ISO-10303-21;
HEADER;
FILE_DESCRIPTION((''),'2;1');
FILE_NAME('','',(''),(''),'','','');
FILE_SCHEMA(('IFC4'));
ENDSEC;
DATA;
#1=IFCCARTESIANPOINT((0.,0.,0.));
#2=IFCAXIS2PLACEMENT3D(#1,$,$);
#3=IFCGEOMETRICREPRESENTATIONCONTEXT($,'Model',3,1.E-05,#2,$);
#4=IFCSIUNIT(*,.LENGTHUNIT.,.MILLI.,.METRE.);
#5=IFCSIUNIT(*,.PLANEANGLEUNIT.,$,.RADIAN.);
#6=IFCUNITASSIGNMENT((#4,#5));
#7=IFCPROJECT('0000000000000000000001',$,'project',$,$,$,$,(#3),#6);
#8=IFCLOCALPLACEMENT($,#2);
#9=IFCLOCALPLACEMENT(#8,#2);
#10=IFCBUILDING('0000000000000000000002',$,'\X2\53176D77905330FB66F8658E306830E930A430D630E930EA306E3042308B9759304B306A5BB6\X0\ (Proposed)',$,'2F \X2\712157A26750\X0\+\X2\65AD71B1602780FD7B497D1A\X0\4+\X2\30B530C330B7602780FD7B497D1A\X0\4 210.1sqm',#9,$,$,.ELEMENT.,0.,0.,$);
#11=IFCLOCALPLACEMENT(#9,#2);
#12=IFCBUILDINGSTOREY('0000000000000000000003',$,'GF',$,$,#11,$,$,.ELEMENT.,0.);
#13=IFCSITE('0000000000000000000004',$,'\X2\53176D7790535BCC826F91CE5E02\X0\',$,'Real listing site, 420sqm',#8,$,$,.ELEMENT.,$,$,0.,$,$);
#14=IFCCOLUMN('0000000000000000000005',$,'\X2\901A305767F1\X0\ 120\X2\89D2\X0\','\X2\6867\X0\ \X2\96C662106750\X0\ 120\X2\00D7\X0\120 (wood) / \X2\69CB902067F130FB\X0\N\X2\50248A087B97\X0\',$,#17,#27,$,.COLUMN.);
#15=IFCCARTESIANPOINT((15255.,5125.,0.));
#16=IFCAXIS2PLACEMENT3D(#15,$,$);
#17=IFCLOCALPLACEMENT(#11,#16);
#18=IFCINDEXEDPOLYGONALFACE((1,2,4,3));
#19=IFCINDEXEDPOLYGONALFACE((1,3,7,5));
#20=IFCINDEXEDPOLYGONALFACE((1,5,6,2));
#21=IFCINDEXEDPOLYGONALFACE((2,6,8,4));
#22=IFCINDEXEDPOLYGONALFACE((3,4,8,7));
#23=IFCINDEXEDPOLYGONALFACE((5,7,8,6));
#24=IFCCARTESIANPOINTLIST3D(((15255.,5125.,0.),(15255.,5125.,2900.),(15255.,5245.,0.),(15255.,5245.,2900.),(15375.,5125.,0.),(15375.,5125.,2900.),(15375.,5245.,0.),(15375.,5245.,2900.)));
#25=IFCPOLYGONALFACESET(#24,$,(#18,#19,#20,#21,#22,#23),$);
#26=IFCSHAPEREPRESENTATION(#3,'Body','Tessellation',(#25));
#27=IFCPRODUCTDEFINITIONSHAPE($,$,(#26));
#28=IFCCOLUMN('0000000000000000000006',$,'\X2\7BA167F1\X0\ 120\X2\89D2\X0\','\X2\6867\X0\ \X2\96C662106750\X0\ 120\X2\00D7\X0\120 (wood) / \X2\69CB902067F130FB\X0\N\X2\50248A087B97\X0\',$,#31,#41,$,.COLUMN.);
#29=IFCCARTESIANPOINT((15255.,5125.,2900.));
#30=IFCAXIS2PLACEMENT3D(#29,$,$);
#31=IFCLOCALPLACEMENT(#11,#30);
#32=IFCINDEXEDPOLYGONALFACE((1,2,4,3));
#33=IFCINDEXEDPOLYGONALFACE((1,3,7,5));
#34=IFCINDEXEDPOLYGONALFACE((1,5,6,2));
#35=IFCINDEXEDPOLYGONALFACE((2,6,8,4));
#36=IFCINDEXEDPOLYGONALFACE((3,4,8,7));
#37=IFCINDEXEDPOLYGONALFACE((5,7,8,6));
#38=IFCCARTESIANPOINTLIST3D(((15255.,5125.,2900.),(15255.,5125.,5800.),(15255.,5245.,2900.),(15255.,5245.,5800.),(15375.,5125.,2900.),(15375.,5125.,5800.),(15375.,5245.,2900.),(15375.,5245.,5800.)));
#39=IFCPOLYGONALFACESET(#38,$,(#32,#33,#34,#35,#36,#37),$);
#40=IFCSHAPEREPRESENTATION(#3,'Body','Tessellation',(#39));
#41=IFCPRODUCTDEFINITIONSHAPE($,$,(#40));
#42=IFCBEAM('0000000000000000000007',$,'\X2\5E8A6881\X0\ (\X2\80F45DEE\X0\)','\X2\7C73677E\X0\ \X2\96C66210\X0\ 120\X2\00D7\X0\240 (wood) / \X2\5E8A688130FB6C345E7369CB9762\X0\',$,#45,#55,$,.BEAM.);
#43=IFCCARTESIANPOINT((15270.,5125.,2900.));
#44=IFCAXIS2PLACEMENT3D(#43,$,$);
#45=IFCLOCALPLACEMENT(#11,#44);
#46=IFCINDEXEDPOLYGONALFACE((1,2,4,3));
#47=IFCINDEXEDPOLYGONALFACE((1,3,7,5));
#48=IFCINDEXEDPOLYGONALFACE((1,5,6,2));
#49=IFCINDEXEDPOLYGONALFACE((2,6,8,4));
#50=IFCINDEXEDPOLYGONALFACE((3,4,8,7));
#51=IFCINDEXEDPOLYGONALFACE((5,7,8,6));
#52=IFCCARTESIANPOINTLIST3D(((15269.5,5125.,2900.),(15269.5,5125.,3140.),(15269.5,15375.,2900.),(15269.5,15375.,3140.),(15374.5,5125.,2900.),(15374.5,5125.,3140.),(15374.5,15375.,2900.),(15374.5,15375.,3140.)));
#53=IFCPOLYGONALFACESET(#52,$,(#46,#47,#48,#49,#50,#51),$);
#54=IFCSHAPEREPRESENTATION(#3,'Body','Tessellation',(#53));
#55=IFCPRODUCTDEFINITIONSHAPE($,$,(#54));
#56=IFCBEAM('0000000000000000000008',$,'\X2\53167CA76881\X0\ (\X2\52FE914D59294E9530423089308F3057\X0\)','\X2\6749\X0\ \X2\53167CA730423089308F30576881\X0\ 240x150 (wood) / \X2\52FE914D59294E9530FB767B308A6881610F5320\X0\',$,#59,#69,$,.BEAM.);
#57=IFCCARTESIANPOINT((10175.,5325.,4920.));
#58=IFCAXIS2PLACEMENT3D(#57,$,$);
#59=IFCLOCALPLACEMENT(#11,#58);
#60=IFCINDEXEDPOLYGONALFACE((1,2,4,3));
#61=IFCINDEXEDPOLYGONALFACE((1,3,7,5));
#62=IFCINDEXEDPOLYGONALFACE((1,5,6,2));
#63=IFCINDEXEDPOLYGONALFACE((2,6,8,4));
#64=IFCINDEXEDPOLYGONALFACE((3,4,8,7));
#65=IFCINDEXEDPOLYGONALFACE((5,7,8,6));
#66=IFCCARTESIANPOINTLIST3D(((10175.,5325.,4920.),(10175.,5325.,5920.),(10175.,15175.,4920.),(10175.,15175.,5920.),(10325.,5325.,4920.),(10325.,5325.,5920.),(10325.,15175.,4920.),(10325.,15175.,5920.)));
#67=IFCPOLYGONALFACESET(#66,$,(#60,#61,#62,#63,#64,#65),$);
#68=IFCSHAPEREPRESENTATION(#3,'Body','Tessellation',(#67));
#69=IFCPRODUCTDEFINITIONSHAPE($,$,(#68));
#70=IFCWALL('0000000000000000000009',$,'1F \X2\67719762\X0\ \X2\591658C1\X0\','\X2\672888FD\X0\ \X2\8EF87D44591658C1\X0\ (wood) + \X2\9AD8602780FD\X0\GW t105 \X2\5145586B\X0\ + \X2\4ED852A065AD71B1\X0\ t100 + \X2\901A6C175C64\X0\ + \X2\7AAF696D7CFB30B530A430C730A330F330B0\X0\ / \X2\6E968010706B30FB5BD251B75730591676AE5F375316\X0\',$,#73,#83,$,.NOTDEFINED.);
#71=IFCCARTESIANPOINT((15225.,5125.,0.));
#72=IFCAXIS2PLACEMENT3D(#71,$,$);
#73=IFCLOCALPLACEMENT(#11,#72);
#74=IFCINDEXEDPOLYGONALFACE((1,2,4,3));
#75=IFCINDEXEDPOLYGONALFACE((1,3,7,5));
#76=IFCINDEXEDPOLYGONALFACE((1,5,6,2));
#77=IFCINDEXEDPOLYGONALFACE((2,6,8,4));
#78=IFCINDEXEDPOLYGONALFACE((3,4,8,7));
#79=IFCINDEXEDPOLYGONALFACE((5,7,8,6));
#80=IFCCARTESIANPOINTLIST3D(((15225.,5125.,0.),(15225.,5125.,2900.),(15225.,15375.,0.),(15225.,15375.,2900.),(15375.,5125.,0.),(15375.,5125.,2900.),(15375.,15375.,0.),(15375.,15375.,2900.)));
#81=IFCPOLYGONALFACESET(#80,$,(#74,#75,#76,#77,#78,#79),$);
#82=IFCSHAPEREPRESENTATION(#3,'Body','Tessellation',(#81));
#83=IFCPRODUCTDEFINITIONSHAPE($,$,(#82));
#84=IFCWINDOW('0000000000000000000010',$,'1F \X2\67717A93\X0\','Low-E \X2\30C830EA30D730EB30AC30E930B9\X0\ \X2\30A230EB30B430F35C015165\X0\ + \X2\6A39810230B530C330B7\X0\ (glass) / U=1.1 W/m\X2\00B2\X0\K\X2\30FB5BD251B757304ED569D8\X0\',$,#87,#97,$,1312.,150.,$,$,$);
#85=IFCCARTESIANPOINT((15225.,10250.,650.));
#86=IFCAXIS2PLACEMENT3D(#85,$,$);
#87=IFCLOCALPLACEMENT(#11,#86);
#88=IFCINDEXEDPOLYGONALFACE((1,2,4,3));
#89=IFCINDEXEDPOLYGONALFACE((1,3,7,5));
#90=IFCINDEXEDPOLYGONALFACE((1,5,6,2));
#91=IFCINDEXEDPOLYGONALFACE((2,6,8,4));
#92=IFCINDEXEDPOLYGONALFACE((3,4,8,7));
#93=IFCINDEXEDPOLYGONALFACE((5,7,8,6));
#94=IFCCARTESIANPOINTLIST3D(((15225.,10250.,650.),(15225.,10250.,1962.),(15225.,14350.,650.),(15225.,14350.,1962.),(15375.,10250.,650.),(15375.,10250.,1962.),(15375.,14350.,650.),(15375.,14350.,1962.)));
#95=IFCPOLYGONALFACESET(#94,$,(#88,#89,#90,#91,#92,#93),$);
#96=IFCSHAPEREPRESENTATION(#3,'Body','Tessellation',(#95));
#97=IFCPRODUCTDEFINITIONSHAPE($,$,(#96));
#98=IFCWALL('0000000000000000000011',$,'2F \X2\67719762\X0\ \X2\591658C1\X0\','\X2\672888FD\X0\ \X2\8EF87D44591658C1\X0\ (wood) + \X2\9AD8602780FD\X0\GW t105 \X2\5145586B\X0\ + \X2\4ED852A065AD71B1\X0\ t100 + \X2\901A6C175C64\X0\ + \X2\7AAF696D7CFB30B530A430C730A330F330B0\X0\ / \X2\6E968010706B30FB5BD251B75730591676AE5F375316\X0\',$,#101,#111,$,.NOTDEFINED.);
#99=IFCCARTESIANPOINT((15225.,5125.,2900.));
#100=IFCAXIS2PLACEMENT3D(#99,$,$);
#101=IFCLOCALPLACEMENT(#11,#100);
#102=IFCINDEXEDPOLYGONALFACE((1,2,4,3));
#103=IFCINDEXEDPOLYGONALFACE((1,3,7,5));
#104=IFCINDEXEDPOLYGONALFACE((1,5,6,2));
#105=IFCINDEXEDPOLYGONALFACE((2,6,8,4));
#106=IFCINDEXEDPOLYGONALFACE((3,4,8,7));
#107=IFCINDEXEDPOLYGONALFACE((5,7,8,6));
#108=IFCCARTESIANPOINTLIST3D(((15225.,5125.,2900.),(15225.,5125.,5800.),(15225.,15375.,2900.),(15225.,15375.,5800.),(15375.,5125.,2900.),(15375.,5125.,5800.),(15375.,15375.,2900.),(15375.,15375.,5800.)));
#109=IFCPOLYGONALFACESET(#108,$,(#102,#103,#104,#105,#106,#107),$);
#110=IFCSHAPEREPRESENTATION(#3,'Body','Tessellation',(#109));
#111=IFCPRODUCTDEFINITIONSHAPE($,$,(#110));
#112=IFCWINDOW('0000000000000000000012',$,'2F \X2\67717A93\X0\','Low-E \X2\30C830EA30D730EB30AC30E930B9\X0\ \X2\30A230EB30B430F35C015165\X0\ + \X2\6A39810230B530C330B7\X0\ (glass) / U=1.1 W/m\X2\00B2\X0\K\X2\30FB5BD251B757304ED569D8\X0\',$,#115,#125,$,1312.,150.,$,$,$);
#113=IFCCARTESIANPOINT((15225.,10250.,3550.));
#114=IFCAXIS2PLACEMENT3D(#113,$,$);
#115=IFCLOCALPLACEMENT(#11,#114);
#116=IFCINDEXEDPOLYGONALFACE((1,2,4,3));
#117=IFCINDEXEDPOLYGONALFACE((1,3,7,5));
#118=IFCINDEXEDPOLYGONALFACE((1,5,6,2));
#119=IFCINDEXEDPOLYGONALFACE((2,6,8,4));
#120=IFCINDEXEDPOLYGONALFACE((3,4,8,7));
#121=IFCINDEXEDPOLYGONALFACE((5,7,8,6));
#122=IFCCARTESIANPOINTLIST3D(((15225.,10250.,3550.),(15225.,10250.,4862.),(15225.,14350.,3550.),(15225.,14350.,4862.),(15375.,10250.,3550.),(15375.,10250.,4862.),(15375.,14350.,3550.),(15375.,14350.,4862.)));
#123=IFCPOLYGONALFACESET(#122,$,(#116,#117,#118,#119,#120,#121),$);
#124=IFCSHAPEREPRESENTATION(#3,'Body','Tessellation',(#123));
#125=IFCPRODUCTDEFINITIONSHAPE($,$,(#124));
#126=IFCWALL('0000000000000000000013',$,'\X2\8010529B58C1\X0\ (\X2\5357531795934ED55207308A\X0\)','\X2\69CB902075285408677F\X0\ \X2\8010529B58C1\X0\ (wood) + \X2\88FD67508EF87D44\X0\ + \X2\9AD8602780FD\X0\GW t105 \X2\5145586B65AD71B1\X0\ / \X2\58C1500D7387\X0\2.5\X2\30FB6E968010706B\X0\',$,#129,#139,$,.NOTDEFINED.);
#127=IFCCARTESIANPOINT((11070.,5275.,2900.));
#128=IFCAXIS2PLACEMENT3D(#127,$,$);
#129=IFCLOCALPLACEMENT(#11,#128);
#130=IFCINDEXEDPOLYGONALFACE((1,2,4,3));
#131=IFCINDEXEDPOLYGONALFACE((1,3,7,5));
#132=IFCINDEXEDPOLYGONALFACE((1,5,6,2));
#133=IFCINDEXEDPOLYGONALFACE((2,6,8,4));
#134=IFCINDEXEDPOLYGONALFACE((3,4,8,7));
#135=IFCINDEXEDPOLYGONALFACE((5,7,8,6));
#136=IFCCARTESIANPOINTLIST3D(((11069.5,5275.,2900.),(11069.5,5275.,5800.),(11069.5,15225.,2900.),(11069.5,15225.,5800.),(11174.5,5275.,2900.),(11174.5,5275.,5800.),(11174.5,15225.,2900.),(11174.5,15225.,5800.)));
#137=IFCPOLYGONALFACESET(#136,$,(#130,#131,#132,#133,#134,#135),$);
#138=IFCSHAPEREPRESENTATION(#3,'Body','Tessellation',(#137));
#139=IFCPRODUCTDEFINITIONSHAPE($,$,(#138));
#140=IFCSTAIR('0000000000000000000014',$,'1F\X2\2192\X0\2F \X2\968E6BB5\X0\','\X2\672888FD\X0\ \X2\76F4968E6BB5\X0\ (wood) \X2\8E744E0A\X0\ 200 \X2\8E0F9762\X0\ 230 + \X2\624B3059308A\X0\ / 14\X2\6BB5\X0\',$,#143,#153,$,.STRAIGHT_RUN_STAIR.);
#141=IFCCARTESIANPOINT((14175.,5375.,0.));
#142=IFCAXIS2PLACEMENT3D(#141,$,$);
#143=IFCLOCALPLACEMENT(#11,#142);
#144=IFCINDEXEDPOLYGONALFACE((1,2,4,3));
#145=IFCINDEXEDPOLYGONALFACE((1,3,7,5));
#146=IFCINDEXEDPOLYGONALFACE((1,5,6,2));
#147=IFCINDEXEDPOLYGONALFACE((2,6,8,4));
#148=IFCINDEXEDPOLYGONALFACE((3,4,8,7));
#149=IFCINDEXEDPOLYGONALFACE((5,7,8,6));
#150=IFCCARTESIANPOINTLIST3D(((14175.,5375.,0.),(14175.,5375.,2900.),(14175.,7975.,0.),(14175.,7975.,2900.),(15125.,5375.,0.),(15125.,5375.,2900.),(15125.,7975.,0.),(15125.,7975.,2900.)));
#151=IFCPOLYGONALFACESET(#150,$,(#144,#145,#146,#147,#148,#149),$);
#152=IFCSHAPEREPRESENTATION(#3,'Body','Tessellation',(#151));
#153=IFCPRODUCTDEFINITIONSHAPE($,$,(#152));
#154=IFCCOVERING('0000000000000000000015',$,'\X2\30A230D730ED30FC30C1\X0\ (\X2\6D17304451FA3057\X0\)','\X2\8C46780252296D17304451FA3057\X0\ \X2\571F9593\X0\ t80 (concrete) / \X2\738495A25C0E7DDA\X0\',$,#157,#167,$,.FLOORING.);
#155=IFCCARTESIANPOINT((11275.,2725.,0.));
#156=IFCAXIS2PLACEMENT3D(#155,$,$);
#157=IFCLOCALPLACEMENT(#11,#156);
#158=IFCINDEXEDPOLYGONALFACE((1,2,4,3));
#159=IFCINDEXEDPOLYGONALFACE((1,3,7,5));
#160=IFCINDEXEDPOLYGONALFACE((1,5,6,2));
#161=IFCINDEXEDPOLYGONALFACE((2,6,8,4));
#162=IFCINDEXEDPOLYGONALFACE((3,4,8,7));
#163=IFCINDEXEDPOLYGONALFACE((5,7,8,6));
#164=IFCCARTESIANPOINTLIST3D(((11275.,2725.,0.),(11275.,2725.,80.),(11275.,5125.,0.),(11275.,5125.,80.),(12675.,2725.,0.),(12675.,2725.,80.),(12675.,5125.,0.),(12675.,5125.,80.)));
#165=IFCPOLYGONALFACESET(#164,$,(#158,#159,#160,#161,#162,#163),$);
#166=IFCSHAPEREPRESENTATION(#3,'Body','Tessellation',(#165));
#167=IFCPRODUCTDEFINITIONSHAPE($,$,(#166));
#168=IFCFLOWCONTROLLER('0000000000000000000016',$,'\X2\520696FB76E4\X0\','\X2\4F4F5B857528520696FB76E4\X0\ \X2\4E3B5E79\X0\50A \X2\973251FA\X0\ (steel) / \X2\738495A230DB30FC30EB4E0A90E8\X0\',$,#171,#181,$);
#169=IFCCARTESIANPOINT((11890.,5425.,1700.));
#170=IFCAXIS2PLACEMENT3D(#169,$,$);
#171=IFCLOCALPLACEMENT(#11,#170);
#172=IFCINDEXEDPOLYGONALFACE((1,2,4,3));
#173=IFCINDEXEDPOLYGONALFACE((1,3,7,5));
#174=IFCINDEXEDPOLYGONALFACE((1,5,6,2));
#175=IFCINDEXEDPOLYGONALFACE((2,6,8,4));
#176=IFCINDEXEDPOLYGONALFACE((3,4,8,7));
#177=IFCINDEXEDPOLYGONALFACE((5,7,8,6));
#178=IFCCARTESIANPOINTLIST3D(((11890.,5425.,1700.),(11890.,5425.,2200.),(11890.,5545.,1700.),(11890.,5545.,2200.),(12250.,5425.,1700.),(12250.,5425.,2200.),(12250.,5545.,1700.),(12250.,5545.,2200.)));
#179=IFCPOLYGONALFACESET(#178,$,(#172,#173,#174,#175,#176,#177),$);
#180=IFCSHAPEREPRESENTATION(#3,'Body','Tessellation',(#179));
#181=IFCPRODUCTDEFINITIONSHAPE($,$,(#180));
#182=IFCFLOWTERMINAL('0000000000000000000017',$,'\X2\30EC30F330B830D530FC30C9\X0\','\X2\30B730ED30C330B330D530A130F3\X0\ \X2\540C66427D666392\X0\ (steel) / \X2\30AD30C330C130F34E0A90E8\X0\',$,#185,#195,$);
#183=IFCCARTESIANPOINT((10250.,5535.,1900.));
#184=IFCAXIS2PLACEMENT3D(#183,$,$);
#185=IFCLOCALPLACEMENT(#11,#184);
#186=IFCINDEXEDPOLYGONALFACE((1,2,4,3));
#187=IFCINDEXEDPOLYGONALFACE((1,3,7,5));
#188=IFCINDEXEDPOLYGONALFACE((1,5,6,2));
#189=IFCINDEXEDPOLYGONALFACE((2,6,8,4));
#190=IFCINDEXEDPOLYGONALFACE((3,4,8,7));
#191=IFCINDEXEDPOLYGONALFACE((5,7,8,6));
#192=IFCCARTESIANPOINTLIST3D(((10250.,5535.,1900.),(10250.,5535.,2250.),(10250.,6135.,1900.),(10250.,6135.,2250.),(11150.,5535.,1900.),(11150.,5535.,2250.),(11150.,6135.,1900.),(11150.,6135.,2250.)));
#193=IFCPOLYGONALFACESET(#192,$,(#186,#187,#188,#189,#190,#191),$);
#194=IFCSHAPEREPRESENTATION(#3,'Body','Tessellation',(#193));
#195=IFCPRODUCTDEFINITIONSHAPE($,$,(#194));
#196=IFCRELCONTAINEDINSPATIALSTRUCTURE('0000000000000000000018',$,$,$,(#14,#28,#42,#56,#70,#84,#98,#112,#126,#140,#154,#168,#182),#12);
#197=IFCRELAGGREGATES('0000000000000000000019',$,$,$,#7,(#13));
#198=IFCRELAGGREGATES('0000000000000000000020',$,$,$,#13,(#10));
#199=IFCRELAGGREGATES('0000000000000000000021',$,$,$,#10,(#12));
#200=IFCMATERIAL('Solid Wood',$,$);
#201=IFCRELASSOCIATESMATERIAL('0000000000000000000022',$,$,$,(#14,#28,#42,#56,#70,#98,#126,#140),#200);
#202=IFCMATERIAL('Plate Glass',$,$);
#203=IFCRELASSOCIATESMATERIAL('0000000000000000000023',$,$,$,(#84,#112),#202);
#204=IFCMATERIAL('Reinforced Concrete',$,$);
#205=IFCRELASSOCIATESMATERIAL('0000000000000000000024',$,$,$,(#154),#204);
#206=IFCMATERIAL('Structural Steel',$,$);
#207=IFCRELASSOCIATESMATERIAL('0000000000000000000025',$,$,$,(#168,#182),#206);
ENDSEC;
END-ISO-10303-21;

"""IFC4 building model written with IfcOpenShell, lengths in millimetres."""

from ifc_helpers import new_model, si_unit, frame, frame_2d, origin, place, context, project, spatial, rectangle, extrude, material, element, fill, save


model = new_model("IFC4")

# Units and contexts
model_context = context("Model", 3, precision=1e-05, world=origin())
ifc_project = project(units=[si_unit("LENGTHUNIT", "METRE", prefix="MILLI"), si_unit("PLANEANGLEUNIT", "RADIAN")], contexts=[model_context])

# Site, building, storey
site_placement = place(None, origin())
site = spatial("IfcSite", under=ifc_project, at=site_placement, Name="北海道富良野市", ObjectType="Real listing site, 420sqm", CompositionType="ELEMENT", RefElevation=0.0)
building_placement = place(site_placement, origin())
building = spatial("IfcBuilding", under=site, at=building_placement, Name="北海道・書斎とライブラリのある静かな家 (Proposed)", ObjectType="2F 無垢材+断熱性能等級4+サッシ性能等級4 210.1sqm", CompositionType="ELEMENT", ElevationOfRefHeight=0.0, ElevationOfTerrain=0.0)
storey_placement = place(building_placement, origin())
storey = spatial("IfcBuildingStorey", under=building, at=storey_placement, Name="GF", CompositionType="ELEMENT", Elevation=0.0)

# Columns
ifc_material_1 = material(Name="Solid Wood")
column_1_placement = place(storey_placement, frame((15255.0, 5125.0, 0.0)))
element("IfcColumn", 1, at=column_1_placement, inside=storey, material=ifc_material_1, Name="通し柱 120角", Description="桧 集成材 120×120 (wood) / 構造柱・N値計算", PredefinedType="COLUMN", context=model_context, shape_type="SweptSolid", body=[
    extrude(rectangle(XDim=120.0, YDim=120.0, at=frame_2d((60.0, 60.0))), frame((15255.0, 5125.0, 0.0)), (0.0, 0.0, 1.0), 2900.0),
])
column_2_placement = place(storey_placement, frame((15255.0, 5125.0, 2900.0)))
element("IfcColumn", 2, at=column_2_placement, inside=storey, material=ifc_material_1, Name="管柱 120角", Description="桧 集成材 120×120 (wood) / 構造柱・N値計算", PredefinedType="COLUMN", context=model_context, shape_type="SweptSolid", body=[
    extrude(rectangle(XDim=120.0, YDim=120.0, at=frame_2d((60.0, 60.0))), frame((15255.0, 5125.0, 2900.0)), (0.0, 0.0, 1.0), 2900.0),
])

# Beams
beam_1_placement = place(storey_placement, frame((15270.0, 5125.0, 2900.0)))
element("IfcBeam", 3, at=beam_1_placement, inside=storey, material=ifc_material_1, Name="床梁 (胴差)", Description="米松 集成 120×240 (wood) / 床梁・水平構面", PredefinedType="BEAM", context=model_context, shape_type="SweptSolid", body=[
    extrude(rectangle(XDim=105.0, YDim=10250.0, at=frame_2d((52.0, 5125.0))), frame((15270.0, 5125.0, 2900.0)), (0.0, 0.0, 1.0), 240.0),
])
beam_2_placement = place(storey_placement, frame((10175.0, 5325.0, 4920.0)))
element("IfcBeam", 4, at=beam_2_placement, inside=storey, material=ifc_material_1, Name="化粧梁 (勾配天井あらわし)", Description="杉 化粧あらわし梁 240x150 (wood) / 勾配天井・登り梁意匠", PredefinedType="BEAM", context=model_context, shape_type="SweptSolid", body=[
    extrude(rectangle(XDim=150.0, YDim=9850.0, at=frame_2d((75.0, 4925.0))), frame((10175.0, 5325.0, 4920.0)), (0.0, 0.0, 1.0), 1000.0),
])

# Wall, opening, window
wall_1_placement = place(storey_placement, frame((15225.0, 5125.0, 0.0)))
wall_1 = element("IfcWall", 5, at=wall_1_placement, inside=storey, material=ifc_material_1, Name="1F 東面 外壁", Description="木製 軸組外壁 (wood) + 高性能GW t105 充填 + 付加断熱 t100 + 通気層 + 窯業系サイディング / 準耐火・寒冷地外皮強化", PredefinedType="NOTDEFINED", context=model_context, shape_type="SweptSolid", body=[
    extrude(rectangle(XDim=150.0, YDim=10250.0, at=frame_2d((75.0, 5125.0))), frame((15225.0, 5125.0, 0.0)), (0.0, 0.0, 1.0), 2900.0),
])
opening_1_placement = place(storey_placement, frame((15225.0, 10250.0, 650.0)))
opening_1 = element("IfcOpeningElement", 6, at=opening_1_placement, cuts=wall_1, PredefinedType="NOTDEFINED", context=model_context, shape_type="SweptSolid", body=[
    extrude(rectangle(XDim=150.0, YDim=4100.0, at=frame_2d((75.0, 2050.0))), frame((15225.0, 10250.0, 650.0)), (0.0, 0.0, 1.0), 1312.0),
])
ifc_material_2 = material(Name="Plate Glass")
window_1_placement = place(storey_placement, frame((15225.0, 10250.0, 650.0)))
window_1 = element("IfcWindow", 7, at=window_1_placement, inside=storey, material=ifc_material_2, Name="1F 東窓", Description="Low-E トリプルガラス アルゴン封入 + 樹脂サッシ (glass) / U=1.1 W/m²K・寒冷地仕様", OverallHeight=1312.0, OverallWidth=150.0, context=model_context, shape_type="SweptSolid", body=[
    extrude(rectangle(XDim=150.0, YDim=4100.0, at=frame_2d((75.0, 2050.0))), frame((15225.0, 10250.0, 650.0)), (0.0, 0.0, 1.0), 1312.0),
])
fill(opening_1, window_1)

# Wall, opening, window
wall_2_placement = place(storey_placement, frame((15225.0, 5125.0, 2900.0)))
wall_2 = element("IfcWall", 8, at=wall_2_placement, inside=storey, material=ifc_material_1, Name="2F 東面 外壁", Description="木製 軸組外壁 (wood) + 高性能GW t105 充填 + 付加断熱 t100 + 通気層 + 窯業系サイディング / 準耐火・寒冷地外皮強化", PredefinedType="NOTDEFINED", context=model_context, shape_type="SweptSolid", body=[
    extrude(rectangle(XDim=150.0, YDim=10250.0, at=frame_2d((75.0, 5125.0))), frame((15225.0, 5125.0, 2900.0)), (0.0, 0.0, 1.0), 2900.0),
])
opening_2_placement = place(storey_placement, frame((15225.0, 10250.0, 3550.0)))
opening_2 = element("IfcOpeningElement", 9, at=opening_2_placement, cuts=wall_2, PredefinedType="NOTDEFINED", context=model_context, shape_type="SweptSolid", body=[
    extrude(rectangle(XDim=150.0, YDim=4100.0, at=frame_2d((75.0, 2050.0))), frame((15225.0, 10250.0, 3550.0)), (0.0, 0.0, 1.0), 1312.0),
])
window_2_placement = place(storey_placement, frame((15225.0, 10250.0, 3550.0)))
window_2 = element("IfcWindow", 10, at=window_2_placement, inside=storey, material=ifc_material_2, Name="2F 東窓", Description="Low-E トリプルガラス アルゴン封入 + 樹脂サッシ (glass) / U=1.1 W/m²K・寒冷地仕様", OverallHeight=1312.0, OverallWidth=150.0, context=model_context, shape_type="SweptSolid", body=[
    extrude(rectangle(XDim=150.0, YDim=4100.0, at=frame_2d((75.0, 2050.0))), frame((15225.0, 10250.0, 3550.0)), (0.0, 0.0, 1.0), 1312.0),
])
fill(opening_2, window_2)

# Wall
wall_3_placement = place(storey_placement, frame((11070.0, 5275.0, 2900.0)))
element("IfcWall", 11, at=wall_3_placement, inside=storey, material=ifc_material_1, Name="耐力壁 (南北間仕切り)", Description="構造用合板 耐力壁 (wood) + 製材軸組 + 高性能GW t105 充填断熱 / 壁倍率2.5・準耐火", PredefinedType="NOTDEFINED", context=model_context, shape_type="SweptSolid", body=[
    extrude(rectangle(XDim=105.0, YDim=9950.0, at=frame_2d((52.0, 4975.0))), frame((11070.0, 5275.0, 2900.0)), (0.0, 0.0, 1.0), 2900.0),
])

# Stair
stair_placement = place(storey_placement, frame((14175.0, 5375.0, 0.0)))
element("IfcStair", 12, at=stair_placement, inside=storey, material=ifc_material_1, Name="1F→2F 階段", Description="木製 直階段 (wood) 蹴上 200 踏面 230 + 手すり / 14段", PredefinedType="STRAIGHT_RUN_STAIR", context=model_context, shape_type="SweptSolid", body=[
    extrude(rectangle(XDim=950.0, YDim=2600.0, at=frame_2d((475.0, 1300.0))), frame((14175.0, 5375.0, 0.0)), (0.0, 0.0, 1.0), 2900.0),
])

# Covering
ifc_material_3 = material(Name="Reinforced Concrete")
covering_placement = place(storey_placement, frame((11275.0, 2725.0, 0.0)))
element("IfcCovering", 13, at=covering_placement, inside=storey, material=ifc_material_3, Name="アプローチ (洗い出し)", Description="豆砂利洗い出し 土間 t80 (concrete) / 玄関導線", PredefinedType="FLOORING", context=model_context, shape_type="SweptSolid", body=[
    extrude(rectangle(XDim=1400.0, YDim=2400.0, at=frame_2d((700.0, 1200.0))), frame((11275.0, 2725.0, 0.0)), (0.0, 0.0, 1.0), 80.0),
])

# Flow controller
ifc_material_4 = material(Name="Structural Steel")
flow_controller_placement = place(storey_placement, frame((11890.0, 5425.0, 1700.0)))
element("IfcFlowController", 14, at=flow_controller_placement, inside=storey, material=ifc_material_4, Name="分電盤", Description="住宅用分電盤 主幹50A 露出 (steel) / 玄関ホール上部", context=model_context, shape_type="SweptSolid", body=[
    extrude(rectangle(XDim=360.0, YDim=120.0, at=frame_2d((180.0, 60.0))), frame((11890.0, 5425.0, 1700.0)), (0.0, 0.0, 1.0), 500.0),
])

# Flow terminal
flow_terminal_1_placement = place(storey_placement, frame((10250.0, 5535.0, 1900.0)))
element("IfcFlowTerminal", 15, at=flow_terminal_1_placement, inside=storey, material=ifc_material_4, Name="レンジフード", Description="シロッコファン 同時給排 (steel) / キッチン上部", context=model_context, shape_type="SweptSolid", body=[
    extrude(rectangle(XDim=900.0, YDim=600.0, at=frame_2d((450.0, 300.0))), frame((10250.0, 5535.0, 1900.0)), (0.0, 0.0, 1.0), 350.0),
])

save(model, "model.ifc")
